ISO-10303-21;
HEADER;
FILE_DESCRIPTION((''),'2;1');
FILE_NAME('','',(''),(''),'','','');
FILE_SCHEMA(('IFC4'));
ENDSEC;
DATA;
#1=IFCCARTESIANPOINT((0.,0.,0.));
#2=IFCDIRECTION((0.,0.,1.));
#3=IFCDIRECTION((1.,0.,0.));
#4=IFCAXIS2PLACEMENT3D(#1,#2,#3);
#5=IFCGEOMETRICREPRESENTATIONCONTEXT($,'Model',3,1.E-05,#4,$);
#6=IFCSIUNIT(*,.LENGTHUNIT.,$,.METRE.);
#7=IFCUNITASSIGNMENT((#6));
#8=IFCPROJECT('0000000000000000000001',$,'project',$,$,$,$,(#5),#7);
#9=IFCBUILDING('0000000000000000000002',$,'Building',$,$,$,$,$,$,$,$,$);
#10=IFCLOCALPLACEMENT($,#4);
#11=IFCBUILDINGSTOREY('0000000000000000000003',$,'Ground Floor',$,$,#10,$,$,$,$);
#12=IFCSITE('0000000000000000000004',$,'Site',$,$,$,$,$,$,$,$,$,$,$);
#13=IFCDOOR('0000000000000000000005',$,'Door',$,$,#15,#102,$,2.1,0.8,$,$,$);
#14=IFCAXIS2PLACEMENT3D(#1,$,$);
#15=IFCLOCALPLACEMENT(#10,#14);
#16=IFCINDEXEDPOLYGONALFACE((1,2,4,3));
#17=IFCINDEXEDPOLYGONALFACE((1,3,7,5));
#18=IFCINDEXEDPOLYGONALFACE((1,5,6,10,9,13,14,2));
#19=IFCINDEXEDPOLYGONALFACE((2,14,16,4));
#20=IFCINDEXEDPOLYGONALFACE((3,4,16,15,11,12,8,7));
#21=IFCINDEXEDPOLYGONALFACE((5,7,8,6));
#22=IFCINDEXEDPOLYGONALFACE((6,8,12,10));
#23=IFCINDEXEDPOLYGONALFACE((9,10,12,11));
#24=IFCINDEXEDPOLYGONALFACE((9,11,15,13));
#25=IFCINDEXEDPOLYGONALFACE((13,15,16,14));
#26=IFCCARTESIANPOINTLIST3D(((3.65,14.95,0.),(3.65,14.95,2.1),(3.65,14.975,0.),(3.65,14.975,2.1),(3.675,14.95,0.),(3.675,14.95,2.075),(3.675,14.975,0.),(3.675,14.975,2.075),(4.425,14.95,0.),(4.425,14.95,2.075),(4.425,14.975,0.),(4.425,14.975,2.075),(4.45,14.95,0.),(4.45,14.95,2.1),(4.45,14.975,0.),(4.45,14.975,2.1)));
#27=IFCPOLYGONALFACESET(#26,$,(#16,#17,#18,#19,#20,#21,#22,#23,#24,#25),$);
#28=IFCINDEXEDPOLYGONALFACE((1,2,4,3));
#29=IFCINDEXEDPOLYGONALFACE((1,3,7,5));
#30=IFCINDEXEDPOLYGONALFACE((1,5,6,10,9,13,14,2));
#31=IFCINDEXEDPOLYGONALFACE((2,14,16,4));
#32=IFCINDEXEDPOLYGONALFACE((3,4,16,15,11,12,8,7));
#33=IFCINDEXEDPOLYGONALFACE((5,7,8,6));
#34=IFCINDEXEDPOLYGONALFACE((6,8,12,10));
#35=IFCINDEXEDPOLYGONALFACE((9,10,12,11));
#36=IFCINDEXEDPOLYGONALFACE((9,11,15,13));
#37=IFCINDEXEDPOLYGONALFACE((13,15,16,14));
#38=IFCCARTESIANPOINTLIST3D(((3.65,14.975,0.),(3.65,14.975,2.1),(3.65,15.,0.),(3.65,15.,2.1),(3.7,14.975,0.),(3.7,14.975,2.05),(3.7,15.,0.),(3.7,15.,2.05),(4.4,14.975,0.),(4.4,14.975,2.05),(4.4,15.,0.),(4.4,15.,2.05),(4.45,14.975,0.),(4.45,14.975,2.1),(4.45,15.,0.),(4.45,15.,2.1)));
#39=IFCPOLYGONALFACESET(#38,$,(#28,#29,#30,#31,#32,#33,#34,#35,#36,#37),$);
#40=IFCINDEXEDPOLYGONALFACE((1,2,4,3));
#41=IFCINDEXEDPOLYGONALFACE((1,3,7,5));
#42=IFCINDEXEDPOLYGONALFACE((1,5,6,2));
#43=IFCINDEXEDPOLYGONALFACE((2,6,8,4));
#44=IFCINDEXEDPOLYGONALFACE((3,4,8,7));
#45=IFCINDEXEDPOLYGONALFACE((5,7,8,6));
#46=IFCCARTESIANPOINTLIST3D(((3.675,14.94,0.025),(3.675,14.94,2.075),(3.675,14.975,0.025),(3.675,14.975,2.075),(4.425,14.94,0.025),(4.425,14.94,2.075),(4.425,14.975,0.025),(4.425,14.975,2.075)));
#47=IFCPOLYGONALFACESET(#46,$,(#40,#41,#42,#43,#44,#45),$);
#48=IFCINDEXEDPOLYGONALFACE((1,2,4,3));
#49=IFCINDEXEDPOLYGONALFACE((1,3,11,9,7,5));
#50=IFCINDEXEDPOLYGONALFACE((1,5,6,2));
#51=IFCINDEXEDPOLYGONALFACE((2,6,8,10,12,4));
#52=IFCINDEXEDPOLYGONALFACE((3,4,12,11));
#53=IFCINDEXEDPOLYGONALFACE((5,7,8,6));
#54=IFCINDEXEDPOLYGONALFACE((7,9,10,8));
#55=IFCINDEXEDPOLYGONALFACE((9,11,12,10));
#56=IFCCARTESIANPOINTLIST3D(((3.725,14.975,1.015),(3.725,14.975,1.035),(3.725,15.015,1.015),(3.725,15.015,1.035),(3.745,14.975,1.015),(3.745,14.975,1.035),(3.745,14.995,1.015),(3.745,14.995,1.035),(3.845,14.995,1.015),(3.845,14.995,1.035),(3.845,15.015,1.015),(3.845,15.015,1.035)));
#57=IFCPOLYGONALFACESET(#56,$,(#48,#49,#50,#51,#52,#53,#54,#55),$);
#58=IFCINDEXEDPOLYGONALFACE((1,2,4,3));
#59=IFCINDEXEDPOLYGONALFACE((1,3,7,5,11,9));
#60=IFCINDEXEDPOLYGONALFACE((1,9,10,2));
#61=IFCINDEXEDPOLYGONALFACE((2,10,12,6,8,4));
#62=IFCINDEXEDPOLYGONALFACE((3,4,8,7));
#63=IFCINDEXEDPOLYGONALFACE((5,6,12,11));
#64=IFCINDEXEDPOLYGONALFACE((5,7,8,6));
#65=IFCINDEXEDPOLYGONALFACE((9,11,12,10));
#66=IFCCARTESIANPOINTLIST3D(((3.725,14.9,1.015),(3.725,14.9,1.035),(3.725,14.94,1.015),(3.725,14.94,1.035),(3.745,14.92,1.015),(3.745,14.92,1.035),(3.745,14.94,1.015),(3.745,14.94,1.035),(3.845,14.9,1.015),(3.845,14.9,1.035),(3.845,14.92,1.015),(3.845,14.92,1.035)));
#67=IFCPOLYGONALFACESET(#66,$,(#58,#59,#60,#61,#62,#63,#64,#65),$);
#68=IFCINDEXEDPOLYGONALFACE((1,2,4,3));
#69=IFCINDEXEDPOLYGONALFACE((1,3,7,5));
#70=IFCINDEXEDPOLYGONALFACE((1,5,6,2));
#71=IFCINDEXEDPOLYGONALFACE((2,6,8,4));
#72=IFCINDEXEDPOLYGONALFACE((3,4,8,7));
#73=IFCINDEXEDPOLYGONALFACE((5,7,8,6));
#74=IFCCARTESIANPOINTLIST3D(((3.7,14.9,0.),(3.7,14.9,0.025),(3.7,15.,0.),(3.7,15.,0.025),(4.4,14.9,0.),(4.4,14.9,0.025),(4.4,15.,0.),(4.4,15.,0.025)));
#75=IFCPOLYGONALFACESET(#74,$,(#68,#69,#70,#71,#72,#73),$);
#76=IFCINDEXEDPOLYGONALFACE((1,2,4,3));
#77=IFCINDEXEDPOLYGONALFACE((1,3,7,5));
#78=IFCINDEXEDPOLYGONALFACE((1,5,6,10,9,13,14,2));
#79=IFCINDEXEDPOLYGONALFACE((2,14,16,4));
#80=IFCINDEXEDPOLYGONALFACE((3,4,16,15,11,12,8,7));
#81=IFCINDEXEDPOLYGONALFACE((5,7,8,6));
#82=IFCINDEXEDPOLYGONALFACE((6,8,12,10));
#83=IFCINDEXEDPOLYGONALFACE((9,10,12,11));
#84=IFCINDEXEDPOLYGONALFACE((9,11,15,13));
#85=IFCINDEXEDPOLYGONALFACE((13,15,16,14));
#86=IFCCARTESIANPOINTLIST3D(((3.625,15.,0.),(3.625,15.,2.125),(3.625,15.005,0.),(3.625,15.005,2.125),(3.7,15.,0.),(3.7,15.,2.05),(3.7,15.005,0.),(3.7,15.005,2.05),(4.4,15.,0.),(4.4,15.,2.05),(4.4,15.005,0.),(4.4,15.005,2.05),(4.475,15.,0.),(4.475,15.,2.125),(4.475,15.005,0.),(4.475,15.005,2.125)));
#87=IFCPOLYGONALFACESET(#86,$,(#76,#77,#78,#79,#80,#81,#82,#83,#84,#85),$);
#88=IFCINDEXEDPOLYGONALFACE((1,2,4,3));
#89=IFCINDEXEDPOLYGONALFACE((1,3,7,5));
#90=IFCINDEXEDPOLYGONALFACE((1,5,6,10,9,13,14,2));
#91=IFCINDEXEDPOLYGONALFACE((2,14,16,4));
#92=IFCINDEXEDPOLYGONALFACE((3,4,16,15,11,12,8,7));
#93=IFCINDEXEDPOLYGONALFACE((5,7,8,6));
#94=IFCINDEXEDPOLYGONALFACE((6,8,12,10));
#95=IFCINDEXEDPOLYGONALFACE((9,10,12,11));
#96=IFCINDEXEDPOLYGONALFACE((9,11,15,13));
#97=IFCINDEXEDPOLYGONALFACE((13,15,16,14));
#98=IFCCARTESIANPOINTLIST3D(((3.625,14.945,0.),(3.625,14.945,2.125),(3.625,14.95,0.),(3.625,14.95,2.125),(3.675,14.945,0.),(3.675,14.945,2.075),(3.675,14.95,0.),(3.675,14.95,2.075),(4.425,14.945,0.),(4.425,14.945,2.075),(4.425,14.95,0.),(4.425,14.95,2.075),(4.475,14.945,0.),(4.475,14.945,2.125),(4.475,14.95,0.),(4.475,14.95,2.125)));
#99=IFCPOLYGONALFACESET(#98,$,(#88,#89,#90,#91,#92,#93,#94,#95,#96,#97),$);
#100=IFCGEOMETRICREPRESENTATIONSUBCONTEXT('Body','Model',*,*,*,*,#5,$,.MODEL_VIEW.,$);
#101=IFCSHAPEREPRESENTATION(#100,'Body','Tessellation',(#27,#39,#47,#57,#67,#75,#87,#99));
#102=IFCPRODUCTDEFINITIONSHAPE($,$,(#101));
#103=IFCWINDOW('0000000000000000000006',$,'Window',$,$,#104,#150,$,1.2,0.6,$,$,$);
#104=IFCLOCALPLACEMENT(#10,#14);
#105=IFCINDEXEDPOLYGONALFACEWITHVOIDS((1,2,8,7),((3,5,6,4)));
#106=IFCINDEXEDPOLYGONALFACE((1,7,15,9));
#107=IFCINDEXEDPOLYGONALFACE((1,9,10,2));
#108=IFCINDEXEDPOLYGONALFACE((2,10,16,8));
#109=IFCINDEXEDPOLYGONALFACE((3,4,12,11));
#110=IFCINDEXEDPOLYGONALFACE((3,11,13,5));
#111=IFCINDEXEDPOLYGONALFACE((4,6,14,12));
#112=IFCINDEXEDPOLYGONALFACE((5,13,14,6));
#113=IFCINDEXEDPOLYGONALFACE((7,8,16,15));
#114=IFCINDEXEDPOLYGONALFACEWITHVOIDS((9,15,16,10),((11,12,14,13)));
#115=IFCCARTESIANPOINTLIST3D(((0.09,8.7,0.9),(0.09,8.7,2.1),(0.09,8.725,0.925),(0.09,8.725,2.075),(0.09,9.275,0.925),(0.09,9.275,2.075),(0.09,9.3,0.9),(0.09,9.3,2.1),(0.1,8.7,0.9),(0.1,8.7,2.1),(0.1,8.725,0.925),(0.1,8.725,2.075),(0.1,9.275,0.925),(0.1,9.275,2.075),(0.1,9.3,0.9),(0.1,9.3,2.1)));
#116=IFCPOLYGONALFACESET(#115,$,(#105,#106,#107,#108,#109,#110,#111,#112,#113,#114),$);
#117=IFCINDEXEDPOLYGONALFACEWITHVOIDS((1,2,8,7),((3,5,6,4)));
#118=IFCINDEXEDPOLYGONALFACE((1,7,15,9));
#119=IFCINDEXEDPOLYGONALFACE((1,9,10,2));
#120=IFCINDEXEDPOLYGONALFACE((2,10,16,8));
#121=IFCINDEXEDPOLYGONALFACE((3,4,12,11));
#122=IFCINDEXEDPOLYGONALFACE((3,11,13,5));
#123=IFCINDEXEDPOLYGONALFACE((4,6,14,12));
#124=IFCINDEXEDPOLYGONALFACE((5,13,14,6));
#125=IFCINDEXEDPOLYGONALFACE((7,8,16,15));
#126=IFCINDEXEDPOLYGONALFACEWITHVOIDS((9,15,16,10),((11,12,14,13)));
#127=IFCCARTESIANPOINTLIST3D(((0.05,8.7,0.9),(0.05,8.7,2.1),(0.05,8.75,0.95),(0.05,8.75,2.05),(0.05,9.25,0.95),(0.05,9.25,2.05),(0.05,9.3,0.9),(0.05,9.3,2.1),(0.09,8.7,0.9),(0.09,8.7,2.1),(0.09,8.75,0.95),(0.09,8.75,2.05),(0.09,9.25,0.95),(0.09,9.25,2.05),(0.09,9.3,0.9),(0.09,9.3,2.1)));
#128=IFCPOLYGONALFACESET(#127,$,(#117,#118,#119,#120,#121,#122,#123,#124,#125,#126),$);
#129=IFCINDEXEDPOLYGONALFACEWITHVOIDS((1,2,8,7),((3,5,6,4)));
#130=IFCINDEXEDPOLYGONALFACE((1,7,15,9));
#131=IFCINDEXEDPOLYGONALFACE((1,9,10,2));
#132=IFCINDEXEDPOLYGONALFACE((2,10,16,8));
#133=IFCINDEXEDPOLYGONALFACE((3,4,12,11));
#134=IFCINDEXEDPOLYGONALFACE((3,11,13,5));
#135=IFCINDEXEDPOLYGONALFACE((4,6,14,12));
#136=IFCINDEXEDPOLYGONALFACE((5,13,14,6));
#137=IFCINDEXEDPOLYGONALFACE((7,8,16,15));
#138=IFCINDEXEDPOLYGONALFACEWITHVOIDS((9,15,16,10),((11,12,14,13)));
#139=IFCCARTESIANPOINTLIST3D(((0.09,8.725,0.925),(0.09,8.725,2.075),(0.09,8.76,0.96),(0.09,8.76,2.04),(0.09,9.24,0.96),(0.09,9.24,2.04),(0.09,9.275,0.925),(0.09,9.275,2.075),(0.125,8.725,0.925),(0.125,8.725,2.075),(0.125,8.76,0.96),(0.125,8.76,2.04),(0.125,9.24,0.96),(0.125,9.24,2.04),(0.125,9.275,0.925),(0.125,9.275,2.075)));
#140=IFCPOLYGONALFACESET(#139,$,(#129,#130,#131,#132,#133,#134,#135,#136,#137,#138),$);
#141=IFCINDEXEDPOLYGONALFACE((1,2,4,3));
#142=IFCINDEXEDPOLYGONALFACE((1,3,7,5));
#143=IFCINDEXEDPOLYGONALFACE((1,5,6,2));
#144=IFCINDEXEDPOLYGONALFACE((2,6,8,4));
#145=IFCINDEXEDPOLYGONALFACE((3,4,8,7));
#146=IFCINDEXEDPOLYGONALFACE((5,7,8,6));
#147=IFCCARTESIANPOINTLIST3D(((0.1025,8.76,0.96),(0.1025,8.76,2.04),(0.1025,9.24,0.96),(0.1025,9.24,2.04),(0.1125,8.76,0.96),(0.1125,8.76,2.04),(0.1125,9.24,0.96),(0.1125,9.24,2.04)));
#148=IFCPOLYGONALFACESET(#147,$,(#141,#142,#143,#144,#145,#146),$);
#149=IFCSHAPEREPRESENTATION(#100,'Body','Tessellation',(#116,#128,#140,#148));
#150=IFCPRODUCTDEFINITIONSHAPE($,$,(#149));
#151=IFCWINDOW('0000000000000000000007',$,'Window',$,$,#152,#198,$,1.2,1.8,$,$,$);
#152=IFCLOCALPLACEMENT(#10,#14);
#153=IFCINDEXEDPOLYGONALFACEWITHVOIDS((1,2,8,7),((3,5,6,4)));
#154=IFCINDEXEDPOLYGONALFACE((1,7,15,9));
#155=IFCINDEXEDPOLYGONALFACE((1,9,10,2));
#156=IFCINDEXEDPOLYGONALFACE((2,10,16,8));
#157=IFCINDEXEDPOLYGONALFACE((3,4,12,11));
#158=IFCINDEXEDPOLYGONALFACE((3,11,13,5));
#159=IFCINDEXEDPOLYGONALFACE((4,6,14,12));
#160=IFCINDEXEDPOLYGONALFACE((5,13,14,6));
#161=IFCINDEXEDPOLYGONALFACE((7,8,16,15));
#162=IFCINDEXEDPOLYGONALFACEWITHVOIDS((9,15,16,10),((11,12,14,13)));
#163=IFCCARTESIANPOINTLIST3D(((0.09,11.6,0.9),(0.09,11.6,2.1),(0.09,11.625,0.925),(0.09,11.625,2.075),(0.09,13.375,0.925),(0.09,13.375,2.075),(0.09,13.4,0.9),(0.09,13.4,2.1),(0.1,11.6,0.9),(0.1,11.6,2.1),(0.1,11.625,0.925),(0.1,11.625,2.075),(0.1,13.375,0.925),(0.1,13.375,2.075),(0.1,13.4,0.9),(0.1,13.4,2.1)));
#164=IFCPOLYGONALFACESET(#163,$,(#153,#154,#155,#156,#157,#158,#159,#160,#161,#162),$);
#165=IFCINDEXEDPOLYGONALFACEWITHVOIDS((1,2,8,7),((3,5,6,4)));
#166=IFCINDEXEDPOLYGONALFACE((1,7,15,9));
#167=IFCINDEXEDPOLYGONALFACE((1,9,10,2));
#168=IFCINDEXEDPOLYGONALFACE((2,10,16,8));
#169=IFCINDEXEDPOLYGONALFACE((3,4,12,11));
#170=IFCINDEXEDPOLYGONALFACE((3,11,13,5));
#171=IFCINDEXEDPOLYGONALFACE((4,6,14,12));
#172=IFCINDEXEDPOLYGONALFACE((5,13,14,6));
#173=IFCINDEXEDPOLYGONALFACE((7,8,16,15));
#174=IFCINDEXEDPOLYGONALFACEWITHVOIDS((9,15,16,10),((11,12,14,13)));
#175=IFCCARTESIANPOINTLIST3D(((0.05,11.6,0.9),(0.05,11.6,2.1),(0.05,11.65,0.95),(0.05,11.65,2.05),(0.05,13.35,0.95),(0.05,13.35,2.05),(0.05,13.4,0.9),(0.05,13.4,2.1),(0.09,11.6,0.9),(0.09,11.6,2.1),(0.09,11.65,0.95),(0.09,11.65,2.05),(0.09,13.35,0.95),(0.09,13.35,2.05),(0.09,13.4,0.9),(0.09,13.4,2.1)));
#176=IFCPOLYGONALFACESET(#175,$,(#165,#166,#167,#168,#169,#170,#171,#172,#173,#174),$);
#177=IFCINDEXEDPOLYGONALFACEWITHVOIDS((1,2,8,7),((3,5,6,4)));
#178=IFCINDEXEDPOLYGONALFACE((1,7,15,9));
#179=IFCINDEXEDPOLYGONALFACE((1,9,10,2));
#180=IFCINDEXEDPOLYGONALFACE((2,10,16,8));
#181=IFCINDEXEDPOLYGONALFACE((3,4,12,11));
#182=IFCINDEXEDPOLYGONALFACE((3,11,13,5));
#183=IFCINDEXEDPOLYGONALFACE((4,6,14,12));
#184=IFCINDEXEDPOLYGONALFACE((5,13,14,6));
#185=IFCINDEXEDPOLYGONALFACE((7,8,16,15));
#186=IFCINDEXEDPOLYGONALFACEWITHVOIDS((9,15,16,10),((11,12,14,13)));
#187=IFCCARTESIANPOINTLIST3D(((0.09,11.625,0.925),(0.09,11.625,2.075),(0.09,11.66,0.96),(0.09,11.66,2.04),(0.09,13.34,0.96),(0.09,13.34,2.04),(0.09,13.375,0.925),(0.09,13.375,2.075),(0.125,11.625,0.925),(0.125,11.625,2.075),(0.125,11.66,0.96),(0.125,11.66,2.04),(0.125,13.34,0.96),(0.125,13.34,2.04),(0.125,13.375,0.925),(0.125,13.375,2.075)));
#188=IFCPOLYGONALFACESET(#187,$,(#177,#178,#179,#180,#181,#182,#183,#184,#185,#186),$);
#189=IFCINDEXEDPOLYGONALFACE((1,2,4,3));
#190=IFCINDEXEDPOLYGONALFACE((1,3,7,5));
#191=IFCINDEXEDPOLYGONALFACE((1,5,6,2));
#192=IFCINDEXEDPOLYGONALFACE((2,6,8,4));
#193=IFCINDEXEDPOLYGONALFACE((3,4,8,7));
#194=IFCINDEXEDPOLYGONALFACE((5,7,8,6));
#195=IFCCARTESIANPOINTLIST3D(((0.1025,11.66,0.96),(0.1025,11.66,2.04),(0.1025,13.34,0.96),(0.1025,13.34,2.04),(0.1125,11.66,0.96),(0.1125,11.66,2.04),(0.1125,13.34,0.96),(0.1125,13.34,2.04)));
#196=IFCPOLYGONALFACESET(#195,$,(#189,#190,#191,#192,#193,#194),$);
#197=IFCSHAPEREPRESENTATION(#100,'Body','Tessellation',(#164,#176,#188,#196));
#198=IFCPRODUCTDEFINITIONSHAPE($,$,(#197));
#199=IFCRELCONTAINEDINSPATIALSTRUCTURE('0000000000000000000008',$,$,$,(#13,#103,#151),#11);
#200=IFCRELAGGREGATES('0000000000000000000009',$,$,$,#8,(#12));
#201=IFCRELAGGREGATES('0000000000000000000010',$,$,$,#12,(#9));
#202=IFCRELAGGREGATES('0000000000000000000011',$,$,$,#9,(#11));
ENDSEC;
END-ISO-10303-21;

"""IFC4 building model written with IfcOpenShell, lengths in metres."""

from ifc_helpers import new_model, si_unit, frame, origin_with_axes, place, context, subcontext, project, spatial, line, indexed_curve, outline, extrude, element, save


model = new_model("IFC4")

# Units and contexts
model_context = context("Model", 3, precision=1e-05, world=origin_with_axes())
body_context = subcontext(model_context, "Body", "Model", "MODEL_VIEW")
ifc_project = project(units=[si_unit("LENGTHUNIT", "METRE")], contexts=[model_context])

# Site, building, storey
site = spatial("IfcSite", under=ifc_project, Name="Site")
building = spatial("IfcBuilding", under=site, Name="Building")
storey_placement = place(None, origin_with_axes())
storey = spatial("IfcBuildingStorey", under=building, at=storey_placement, Name="Ground Floor")

# Door
door_1_placement = place(storey_placement, frame((4.45, 15.0, 0.0), z_axis=(0.0, 0.0, 1.0), x_axis=(-1.0, 0.0, 0.0)))
element("IfcDoor", 1, at=door_1_placement, inside=storey, Name="Door", OverallHeight=2.1, OverallWidth=0.8, context=body_context, shape_type="SweptSolid", body=[
    extrude(outline(indexed_curve([(0.0, 0.0), (0.0, 2.1), (0.8, 2.1), (0.8, 0.0), (0.775, 0.0), (0.775, 2.075), (0.025, 2.075), (0.025, 0.0)], segments=[line(1, 2, 3, 4, 5, 6, 7, 8, 1)])), frame((0.0, 0.025, 0.0), z_axis=(0.0, -1.0, 0.0), x_axis=(1.0, 0.0, 0.0)), (0.0, 0.0, -1.0), 0.025),
    extrude(outline(indexed_curve([(0.0, 0.0), (0.0, 2.1), (0.8, 2.1), (0.8, 0.0), (0.75, 0.0), (0.75, 2.05), (0.05, 2.05), (0.05, 0.0)], segments=[line(1, 2, 3, 4, 5, 6, 7, 8, 1)])), frame((0.0, 0.0, 0.0), z_axis=(0.0, -1.0, 0.0), x_axis=(1.0, 0.0, 0.0)), (0.0, 0.0, -1.0), 0.025),
    extrude(outline(indexed_curve([(0.0, 0.0), (0.75, 0.0), (0.75, 0.035), (0.0, 0.035)], segments=[line(1, 2, 3, 4, 1)])), frame((0.025, 0.025, 0.025), z_axis=(0.0, 0.0, 1.0), x_axis=(1.0, 0.0, 0.0)), (0.0, 0.0, 1.0), 2.05),
    extrude(outline(indexed_curve([(0.0, 0.0), (0.0, -0.04), (-0.12, -0.04), (-0.12, -0.02), (-0.02, -0.02), (-0.02, 0.0)], segments=[line(1, 2, 3, 4, 5, 6, 1)])), frame((0.725, 0.025, 1.015), z_axis=(0.0, 0.0, 1.0), x_axis=(1.0, 0.0, 0.0)), (0.0, 0.0, 1.0), 0.02),
    extrude(outline(indexed_curve([(0.0, 0.0), (0.0, 0.04), (-0.12, 0.04), (-0.12, 0.02), (-0.02, 0.02), (-0.02, 0.0)], segments=[line(1, 2, 3, 4, 5, 6, 1)])), frame((0.725, 0.06, 1.015), z_axis=(0.0, 0.0, 1.0), x_axis=(1.0, 0.0, 0.0)), (0.0, 0.0, 1.0), 0.02),
    extrude(outline(indexed_curve([(0.0, 0.0), (0.7, 0.0), (0.7, 0.1), (0.0, 0.1)], segments=[line(1, 2, 3, 4, 1)])), frame((0.05, 0.0, 0.0), z_axis=(0.0, 0.0, 1.0), x_axis=(1.0, 0.0, 0.0)), (0.0, 0.0, 1.0), 0.025),
    extrude(outline(indexed_curve([(0.0, 0.0), (0.0, 2.125), (0.85, 2.125), (0.85, 0.0), (0.775, 0.0), (0.775, 2.05), (0.075, 2.05), (0.075, 0.0)], segments=[line(1, 2, 3, 4, 5, 6, 7, 8, 1)])), frame((-0.025, -0.005, 0.0), z_axis=(0.0, -1.0, 0.0), x_axis=(1.0, 0.0, 0.0)), (0.0, 0.0, -1.0), 0.005),
    extrude(outline(indexed_curve([(0.0, 0.0), (0.0, 2.125), (0.85, 2.125), (0.85, 0.0), (0.8, 0.0), (0.8, 2.075), (0.05, 2.075), (0.05, 0.0)], segments=[line(1, 2, 3, 4, 5, 6, 7, 8, 1)])), frame((-0.025, 0.05, 0.0), z_axis=(0.0, -1.0, 0.0), x_axis=(1.0, 0.0, 0.0)), (0.0, 0.0, -1.0), 0.005),
])

# Windows
window_1_placement = place(storey_placement, frame((0.0, 9.3, 0.9), z_axis=(0.0, 0.0, 1.0), x_axis=(0.0, -1.0, 0.0)))
element("IfcWindow", 2, at=window_1_placement, inside=storey, Name="Window", OverallHeight=1.2, OverallWidth=0.6, context=body_context, shape_type="SweptSolid", body=[
    extrude(outline(indexed_curve([(0.0, 0.0), (0.6, 0.0), (0.6, 1.2), (0.0, 1.2)], segments=[line(1, 2, 3, 4, 1)]), holes=[indexed_curve([(0.025, 0.025), (0.575, 0.025), (0.575, 1.175), (0.025, 1.175)], segments=[line(1, 2, 3, 4, 1)])]), frame((0.0, 0.09, 0.0), z_axis=(0.0, -1.0, 0.0), x_axis=(1.0, 0.0, 0.0)), (0.0, 0.0, -1.0), 0.01),
    extrude(outline(indexed_curve([(0.0, 0.0), (0.6, 0.0), (0.6, 1.2), (0.0, 1.2)], segments=[line(1, 2, 3, 4, 1)]), holes=[indexed_curve([(0.05, 0.05), (0.55, 0.05), (0.55, 1.15), (0.05, 1.15)], segments=[line(1, 2, 3, 4, 1)])]), frame((0.0, 0.05, 0.0), z_axis=(0.0, -1.0, 0.0), x_axis=(1.0, 0.0, 0.0)), (0.0, 0.0, -1.0), 0.04),
    extrude(outline(indexed_curve([(0.0, 0.0), (0.55, 0.0), (0.55, 1.15), (0.0, 1.15)], segments=[line(1, 2, 3, 4, 1)]), holes=[indexed_curve([(0.035, 0.035), (0.515, 0.035), (0.515, 1.115), (0.035, 1.115)], segments=[line(1, 2, 3, 4, 1)])]), frame((0.025, 0.09, 0.025), z_axis=(0.0, -1.0, 0.0), x_axis=(1.0, 0.0, 0.0)), (0.0, 0.0, -1.0), 0.035),
    extrude(outline(indexed_curve([(0.035, 0.035), (0.515, 0.035), (0.515, 1.115), (0.035, 1.115)], segments=[line(1, 2, 3, 4, 1)])), frame((0.025, 0.1025, 0.025), z_axis=(0.0, -1.0, 0.0), x_axis=(1.0, 0.0, 0.0)), (0.0, 0.0, -1.0), 0.01),
])
window_2_placement = place(storey_placement, frame((0.0, 13.4, 0.9), z_axis=(0.0, 0.0, 1.0), x_axis=(0.0, -1.0, 0.0)))
element("IfcWindow", 3, at=window_2_placement, inside=storey, Name="Window", OverallHeight=1.2, OverallWidth=1.8, context=body_context, shape_type="SweptSolid", body=[
    extrude(outline(indexed_curve([(0.0, 0.0), (1.8, 0.0), (1.8, 1.2), (0.0, 1.2)], segments=[line(1, 2, 3, 4, 1)]), holes=[indexed_curve([(0.025, 0.025), (1.775, 0.025), (1.775, 1.175), (0.025, 1.175)], segments=[line(1, 2, 3, 4, 1)])]), frame((0.0, 0.09, 0.0), z_axis=(0.0, -1.0, 0.0), x_axis=(1.0, 0.0, 0.0)), (0.0, 0.0, -1.0), 0.01),
    extrude(outline(indexed_curve([(0.0, 0.0), (1.8, 0.0), (1.8, 1.2), (0.0, 1.2)], segments=[line(1, 2, 3, 4, 1)]), holes=[indexed_curve([(0.05, 0.05), (1.75, 0.05), (1.75, 1.15), (0.05, 1.15)], segments=[line(1, 2, 3, 4, 1)])]), frame((0.0, 0.05, 0.0), z_axis=(0.0, -1.0, 0.0), x_axis=(1.0, 0.0, 0.0)), (0.0, 0.0, -1.0), 0.04),
    extrude(outline(indexed_curve([(0.0, 0.0), (1.75, 0.0), (1.75, 1.15), (0.0, 1.15)], segments=[line(1, 2, 3, 4, 1)]), holes=[indexed_curve([(0.035, 0.035), (1.715, 0.035), (1.715, 1.115), (0.035, 1.115)], segments=[line(1, 2, 3, 4, 1)])]), frame((0.025, 0.09, 0.025), z_axis=(0.0, -1.0, 0.0), x_axis=(1.0, 0.0, 0.0)), (0.0, 0.0, -1.0), 0.035),
    extrude(outline(indexed_curve([(0.035, 0.035), (1.715, 0.035), (1.715, 1.115), (0.035, 1.115)], segments=[line(1, 2, 3, 4, 1)])), frame((0.025, 0.1025, 0.025), z_axis=(0.0, -1.0, 0.0), x_axis=(1.0, 0.0, 0.0)), (0.0, 0.0, -1.0), 0.01),
])

save(model, "model.ifc")
